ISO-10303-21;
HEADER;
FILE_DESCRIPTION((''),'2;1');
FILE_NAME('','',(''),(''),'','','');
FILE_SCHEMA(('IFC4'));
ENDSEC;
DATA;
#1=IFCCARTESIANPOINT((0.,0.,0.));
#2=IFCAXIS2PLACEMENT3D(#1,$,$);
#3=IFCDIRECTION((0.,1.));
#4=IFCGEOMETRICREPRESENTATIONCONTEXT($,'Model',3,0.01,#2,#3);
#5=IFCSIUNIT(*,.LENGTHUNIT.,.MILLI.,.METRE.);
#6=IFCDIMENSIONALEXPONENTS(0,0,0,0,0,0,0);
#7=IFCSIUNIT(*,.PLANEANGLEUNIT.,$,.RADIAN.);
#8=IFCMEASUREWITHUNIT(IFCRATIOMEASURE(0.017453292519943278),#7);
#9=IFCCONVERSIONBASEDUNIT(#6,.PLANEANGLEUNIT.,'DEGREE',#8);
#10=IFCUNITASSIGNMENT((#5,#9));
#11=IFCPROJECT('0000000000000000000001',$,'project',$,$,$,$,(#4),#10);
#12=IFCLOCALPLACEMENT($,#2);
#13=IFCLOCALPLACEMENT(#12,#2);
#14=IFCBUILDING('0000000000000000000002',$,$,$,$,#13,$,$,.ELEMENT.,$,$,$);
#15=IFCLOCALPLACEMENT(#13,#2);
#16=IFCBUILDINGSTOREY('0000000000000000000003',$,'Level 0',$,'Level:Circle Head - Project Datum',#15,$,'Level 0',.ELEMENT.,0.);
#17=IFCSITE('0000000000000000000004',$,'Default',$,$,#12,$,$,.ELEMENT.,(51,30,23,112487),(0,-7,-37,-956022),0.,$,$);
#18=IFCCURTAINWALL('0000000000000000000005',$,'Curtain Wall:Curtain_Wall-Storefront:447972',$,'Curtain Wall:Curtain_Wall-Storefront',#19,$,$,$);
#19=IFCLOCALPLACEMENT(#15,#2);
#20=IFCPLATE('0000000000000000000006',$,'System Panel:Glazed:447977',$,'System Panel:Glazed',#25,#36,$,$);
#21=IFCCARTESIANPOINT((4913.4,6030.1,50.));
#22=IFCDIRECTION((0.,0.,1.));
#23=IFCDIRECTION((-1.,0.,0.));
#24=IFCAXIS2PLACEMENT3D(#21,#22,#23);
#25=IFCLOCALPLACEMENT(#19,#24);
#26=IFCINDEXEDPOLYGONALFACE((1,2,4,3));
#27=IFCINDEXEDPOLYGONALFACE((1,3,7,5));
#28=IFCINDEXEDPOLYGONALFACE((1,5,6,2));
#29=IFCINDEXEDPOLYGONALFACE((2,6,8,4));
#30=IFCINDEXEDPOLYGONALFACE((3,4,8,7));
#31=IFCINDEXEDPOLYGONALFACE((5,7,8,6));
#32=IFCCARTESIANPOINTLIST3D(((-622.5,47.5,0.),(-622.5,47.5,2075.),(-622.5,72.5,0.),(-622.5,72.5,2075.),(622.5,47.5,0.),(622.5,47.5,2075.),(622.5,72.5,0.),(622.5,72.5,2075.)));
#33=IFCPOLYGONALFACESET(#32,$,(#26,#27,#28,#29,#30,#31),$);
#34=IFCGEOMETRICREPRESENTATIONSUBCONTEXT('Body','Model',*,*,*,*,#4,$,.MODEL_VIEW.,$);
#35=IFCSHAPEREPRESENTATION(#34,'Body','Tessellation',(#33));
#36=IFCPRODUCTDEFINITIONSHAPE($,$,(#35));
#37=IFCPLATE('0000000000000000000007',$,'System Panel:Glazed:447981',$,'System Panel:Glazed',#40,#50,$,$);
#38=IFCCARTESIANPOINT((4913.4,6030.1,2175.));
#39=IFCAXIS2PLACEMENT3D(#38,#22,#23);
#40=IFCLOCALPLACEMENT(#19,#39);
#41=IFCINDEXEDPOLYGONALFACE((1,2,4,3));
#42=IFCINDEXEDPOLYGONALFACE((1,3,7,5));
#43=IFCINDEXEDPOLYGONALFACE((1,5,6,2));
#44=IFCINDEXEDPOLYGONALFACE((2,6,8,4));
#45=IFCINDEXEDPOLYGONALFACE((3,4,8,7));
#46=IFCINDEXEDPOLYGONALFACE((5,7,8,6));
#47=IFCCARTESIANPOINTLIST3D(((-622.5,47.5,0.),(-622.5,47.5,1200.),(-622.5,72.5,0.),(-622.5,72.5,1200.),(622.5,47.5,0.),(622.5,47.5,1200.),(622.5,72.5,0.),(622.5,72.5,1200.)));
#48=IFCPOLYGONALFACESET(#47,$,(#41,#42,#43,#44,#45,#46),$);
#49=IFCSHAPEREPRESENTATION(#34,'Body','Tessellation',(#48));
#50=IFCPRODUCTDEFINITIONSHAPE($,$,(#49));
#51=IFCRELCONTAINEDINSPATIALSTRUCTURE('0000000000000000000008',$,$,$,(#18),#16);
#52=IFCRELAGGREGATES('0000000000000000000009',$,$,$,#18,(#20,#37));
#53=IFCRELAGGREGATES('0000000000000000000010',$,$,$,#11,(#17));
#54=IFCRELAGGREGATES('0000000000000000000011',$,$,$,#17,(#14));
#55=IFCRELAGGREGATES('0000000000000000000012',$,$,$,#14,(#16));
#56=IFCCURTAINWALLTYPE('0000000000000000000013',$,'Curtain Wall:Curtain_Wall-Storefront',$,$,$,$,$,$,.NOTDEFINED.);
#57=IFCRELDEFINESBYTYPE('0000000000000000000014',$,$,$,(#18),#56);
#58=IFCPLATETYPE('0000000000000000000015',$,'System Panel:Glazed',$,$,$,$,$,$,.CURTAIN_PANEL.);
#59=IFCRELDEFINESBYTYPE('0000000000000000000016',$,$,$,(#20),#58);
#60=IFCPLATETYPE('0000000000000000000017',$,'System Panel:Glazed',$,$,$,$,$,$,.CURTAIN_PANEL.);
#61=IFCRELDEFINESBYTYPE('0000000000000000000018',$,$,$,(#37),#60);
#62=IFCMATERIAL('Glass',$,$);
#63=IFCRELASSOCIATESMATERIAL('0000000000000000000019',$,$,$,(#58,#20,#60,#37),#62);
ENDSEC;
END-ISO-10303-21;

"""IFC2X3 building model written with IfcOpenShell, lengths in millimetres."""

from ifc_helpers import new_model, entity, si_unit, converted_unit, direction, frame, origin, origin_2d_with_axis, place, context, subcontext, project, spatial, rectangle, extrude, source, transform, mapped, material, type_object, type_shapes, element, aggregate, save


model = new_model("IFC2X3")

# Units and contexts
model_context = context("Model", 3, precision=0.01, world=origin(), true_north=direction((0.0, 1.0)))
body_context = subcontext(model_context, "Body", "Model", "MODEL_VIEW")
ifc_project = project(units=[si_unit("LENGTHUNIT", "METRE", prefix="MILLI"), converted_unit("PLANEANGLEUNIT", "DEGREE", entity("IfcRatioMeasure", 0.017453292519943278), si_unit("PLANEANGLEUNIT", "RADIAN"), dimensions=[0, 0, 0, 0, 0, 0, 0])], contexts=[model_context])

# Site, building, storey
site_placement = place(None, origin())
site = spatial("IfcSite", under=ifc_project, at=site_placement, Name="Default", CompositionType="ELEMENT", RefLatitude=(51, 30, 23, 112487), RefLongitude=(0, -7, -37, -956022), RefElevation=0.0)
building_placement = place(site_placement, origin())
building = spatial("IfcBuilding", under=site, at=building_placement, CompositionType="ELEMENT")
storey_placement = place(building_placement, origin())
storey = spatial("IfcBuildingStorey", under=building, at=storey_placement, Name="Level 0", ObjectType="Level:Circle Head - Project Datum", LongName="Level 0", CompositionType="ELEMENT", Elevation=0.0)

# Curtain wall, plates
curtain_wall_type = type_object("IfcCurtainWallType", Name="Curtain Wall:Curtain_Wall-Storefront", PredefinedType="NOTDEFINED")
curtain_wall_placement = place(storey_placement, origin())
curtain_wall = element("IfcCurtainWall", 1, at=curtain_wall_placement, inside=storey, type_object=curtain_wall_type, Name="Curtain Wall:Curtain_Wall-Storefront:447972", ObjectType="Curtain Wall:Curtain_Wall-Storefront")
ifc_material_1 = material(Name="Glass")
plate_type_1 = type_object("IfcPlateType", Name="System Panel:Glazed", PredefinedType="CURTAIN_PANEL", material=ifc_material_1)
shared_shape_1 = source(origin(), body_context, "Body", "SweptSolid", [
    extrude(rectangle(XDim=25.0, YDim=1245.0, at=origin_2d_with_axis()), frame((0.0, 60.0, 0.0), z_axis=(0.0, 0.0, 1.0), x_axis=(0.0, 1.0, 0.0)), (0.0, 0.0, 1.0), 2075.0),
])
type_shapes(plate_type_1, [shared_shape_1])
plate_1_placement = place(curtain_wall_placement, frame((4913.4, 6030.1, 50.0), z_axis=(0.0, 0.0, 1.0), x_axis=(-1.0, 0.0, 0.0)))
plate_1 = element("IfcPlate", 2, at=plate_1_placement, type_object=plate_type_1, material=ifc_material_1, Name="System Panel:Glazed:447977", ObjectType="System Panel:Glazed", context=body_context, shape_type="MappedRepresentation", body=[
    mapped(shared_shape_1, transform((0.0, 0.0, 0.0), scale=1.0)),
])
plate_type_2 = type_object("IfcPlateType", Name="System Panel:Glazed", PredefinedType="CURTAIN_PANEL", material=ifc_material_1)
shared_shape_2 = source(origin(), body_context, "Body", "SweptSolid", [
    extrude(rectangle(XDim=25.0, YDim=1245.0, at=origin_2d_with_axis()), frame((0.0, 60.0, 0.0), z_axis=(0.0, 0.0, 1.0), x_axis=(0.0, 1.0, 0.0)), (0.0, 0.0, 1.0), 1200.0),
])
type_shapes(plate_type_2, [shared_shape_2])
plate_2_placement = place(curtain_wall_placement, frame((4913.4, 6030.1, 2175.0), z_axis=(0.0, 0.0, 1.0), x_axis=(-1.0, 0.0, 0.0)))
plate_2 = element("IfcPlate", 3, at=plate_2_placement, type_object=plate_type_2, material=ifc_material_1, Name="System Panel:Glazed:447981", ObjectType="System Panel:Glazed", context=body_context, shape_type="MappedRepresentation", body=[
    mapped(shared_shape_2, transform((0.0, 0.0, 0.0), scale=1.0)),
])
aggregate(curtain_wall, [plate_1, plate_2])

save(model, "model.ifc")
